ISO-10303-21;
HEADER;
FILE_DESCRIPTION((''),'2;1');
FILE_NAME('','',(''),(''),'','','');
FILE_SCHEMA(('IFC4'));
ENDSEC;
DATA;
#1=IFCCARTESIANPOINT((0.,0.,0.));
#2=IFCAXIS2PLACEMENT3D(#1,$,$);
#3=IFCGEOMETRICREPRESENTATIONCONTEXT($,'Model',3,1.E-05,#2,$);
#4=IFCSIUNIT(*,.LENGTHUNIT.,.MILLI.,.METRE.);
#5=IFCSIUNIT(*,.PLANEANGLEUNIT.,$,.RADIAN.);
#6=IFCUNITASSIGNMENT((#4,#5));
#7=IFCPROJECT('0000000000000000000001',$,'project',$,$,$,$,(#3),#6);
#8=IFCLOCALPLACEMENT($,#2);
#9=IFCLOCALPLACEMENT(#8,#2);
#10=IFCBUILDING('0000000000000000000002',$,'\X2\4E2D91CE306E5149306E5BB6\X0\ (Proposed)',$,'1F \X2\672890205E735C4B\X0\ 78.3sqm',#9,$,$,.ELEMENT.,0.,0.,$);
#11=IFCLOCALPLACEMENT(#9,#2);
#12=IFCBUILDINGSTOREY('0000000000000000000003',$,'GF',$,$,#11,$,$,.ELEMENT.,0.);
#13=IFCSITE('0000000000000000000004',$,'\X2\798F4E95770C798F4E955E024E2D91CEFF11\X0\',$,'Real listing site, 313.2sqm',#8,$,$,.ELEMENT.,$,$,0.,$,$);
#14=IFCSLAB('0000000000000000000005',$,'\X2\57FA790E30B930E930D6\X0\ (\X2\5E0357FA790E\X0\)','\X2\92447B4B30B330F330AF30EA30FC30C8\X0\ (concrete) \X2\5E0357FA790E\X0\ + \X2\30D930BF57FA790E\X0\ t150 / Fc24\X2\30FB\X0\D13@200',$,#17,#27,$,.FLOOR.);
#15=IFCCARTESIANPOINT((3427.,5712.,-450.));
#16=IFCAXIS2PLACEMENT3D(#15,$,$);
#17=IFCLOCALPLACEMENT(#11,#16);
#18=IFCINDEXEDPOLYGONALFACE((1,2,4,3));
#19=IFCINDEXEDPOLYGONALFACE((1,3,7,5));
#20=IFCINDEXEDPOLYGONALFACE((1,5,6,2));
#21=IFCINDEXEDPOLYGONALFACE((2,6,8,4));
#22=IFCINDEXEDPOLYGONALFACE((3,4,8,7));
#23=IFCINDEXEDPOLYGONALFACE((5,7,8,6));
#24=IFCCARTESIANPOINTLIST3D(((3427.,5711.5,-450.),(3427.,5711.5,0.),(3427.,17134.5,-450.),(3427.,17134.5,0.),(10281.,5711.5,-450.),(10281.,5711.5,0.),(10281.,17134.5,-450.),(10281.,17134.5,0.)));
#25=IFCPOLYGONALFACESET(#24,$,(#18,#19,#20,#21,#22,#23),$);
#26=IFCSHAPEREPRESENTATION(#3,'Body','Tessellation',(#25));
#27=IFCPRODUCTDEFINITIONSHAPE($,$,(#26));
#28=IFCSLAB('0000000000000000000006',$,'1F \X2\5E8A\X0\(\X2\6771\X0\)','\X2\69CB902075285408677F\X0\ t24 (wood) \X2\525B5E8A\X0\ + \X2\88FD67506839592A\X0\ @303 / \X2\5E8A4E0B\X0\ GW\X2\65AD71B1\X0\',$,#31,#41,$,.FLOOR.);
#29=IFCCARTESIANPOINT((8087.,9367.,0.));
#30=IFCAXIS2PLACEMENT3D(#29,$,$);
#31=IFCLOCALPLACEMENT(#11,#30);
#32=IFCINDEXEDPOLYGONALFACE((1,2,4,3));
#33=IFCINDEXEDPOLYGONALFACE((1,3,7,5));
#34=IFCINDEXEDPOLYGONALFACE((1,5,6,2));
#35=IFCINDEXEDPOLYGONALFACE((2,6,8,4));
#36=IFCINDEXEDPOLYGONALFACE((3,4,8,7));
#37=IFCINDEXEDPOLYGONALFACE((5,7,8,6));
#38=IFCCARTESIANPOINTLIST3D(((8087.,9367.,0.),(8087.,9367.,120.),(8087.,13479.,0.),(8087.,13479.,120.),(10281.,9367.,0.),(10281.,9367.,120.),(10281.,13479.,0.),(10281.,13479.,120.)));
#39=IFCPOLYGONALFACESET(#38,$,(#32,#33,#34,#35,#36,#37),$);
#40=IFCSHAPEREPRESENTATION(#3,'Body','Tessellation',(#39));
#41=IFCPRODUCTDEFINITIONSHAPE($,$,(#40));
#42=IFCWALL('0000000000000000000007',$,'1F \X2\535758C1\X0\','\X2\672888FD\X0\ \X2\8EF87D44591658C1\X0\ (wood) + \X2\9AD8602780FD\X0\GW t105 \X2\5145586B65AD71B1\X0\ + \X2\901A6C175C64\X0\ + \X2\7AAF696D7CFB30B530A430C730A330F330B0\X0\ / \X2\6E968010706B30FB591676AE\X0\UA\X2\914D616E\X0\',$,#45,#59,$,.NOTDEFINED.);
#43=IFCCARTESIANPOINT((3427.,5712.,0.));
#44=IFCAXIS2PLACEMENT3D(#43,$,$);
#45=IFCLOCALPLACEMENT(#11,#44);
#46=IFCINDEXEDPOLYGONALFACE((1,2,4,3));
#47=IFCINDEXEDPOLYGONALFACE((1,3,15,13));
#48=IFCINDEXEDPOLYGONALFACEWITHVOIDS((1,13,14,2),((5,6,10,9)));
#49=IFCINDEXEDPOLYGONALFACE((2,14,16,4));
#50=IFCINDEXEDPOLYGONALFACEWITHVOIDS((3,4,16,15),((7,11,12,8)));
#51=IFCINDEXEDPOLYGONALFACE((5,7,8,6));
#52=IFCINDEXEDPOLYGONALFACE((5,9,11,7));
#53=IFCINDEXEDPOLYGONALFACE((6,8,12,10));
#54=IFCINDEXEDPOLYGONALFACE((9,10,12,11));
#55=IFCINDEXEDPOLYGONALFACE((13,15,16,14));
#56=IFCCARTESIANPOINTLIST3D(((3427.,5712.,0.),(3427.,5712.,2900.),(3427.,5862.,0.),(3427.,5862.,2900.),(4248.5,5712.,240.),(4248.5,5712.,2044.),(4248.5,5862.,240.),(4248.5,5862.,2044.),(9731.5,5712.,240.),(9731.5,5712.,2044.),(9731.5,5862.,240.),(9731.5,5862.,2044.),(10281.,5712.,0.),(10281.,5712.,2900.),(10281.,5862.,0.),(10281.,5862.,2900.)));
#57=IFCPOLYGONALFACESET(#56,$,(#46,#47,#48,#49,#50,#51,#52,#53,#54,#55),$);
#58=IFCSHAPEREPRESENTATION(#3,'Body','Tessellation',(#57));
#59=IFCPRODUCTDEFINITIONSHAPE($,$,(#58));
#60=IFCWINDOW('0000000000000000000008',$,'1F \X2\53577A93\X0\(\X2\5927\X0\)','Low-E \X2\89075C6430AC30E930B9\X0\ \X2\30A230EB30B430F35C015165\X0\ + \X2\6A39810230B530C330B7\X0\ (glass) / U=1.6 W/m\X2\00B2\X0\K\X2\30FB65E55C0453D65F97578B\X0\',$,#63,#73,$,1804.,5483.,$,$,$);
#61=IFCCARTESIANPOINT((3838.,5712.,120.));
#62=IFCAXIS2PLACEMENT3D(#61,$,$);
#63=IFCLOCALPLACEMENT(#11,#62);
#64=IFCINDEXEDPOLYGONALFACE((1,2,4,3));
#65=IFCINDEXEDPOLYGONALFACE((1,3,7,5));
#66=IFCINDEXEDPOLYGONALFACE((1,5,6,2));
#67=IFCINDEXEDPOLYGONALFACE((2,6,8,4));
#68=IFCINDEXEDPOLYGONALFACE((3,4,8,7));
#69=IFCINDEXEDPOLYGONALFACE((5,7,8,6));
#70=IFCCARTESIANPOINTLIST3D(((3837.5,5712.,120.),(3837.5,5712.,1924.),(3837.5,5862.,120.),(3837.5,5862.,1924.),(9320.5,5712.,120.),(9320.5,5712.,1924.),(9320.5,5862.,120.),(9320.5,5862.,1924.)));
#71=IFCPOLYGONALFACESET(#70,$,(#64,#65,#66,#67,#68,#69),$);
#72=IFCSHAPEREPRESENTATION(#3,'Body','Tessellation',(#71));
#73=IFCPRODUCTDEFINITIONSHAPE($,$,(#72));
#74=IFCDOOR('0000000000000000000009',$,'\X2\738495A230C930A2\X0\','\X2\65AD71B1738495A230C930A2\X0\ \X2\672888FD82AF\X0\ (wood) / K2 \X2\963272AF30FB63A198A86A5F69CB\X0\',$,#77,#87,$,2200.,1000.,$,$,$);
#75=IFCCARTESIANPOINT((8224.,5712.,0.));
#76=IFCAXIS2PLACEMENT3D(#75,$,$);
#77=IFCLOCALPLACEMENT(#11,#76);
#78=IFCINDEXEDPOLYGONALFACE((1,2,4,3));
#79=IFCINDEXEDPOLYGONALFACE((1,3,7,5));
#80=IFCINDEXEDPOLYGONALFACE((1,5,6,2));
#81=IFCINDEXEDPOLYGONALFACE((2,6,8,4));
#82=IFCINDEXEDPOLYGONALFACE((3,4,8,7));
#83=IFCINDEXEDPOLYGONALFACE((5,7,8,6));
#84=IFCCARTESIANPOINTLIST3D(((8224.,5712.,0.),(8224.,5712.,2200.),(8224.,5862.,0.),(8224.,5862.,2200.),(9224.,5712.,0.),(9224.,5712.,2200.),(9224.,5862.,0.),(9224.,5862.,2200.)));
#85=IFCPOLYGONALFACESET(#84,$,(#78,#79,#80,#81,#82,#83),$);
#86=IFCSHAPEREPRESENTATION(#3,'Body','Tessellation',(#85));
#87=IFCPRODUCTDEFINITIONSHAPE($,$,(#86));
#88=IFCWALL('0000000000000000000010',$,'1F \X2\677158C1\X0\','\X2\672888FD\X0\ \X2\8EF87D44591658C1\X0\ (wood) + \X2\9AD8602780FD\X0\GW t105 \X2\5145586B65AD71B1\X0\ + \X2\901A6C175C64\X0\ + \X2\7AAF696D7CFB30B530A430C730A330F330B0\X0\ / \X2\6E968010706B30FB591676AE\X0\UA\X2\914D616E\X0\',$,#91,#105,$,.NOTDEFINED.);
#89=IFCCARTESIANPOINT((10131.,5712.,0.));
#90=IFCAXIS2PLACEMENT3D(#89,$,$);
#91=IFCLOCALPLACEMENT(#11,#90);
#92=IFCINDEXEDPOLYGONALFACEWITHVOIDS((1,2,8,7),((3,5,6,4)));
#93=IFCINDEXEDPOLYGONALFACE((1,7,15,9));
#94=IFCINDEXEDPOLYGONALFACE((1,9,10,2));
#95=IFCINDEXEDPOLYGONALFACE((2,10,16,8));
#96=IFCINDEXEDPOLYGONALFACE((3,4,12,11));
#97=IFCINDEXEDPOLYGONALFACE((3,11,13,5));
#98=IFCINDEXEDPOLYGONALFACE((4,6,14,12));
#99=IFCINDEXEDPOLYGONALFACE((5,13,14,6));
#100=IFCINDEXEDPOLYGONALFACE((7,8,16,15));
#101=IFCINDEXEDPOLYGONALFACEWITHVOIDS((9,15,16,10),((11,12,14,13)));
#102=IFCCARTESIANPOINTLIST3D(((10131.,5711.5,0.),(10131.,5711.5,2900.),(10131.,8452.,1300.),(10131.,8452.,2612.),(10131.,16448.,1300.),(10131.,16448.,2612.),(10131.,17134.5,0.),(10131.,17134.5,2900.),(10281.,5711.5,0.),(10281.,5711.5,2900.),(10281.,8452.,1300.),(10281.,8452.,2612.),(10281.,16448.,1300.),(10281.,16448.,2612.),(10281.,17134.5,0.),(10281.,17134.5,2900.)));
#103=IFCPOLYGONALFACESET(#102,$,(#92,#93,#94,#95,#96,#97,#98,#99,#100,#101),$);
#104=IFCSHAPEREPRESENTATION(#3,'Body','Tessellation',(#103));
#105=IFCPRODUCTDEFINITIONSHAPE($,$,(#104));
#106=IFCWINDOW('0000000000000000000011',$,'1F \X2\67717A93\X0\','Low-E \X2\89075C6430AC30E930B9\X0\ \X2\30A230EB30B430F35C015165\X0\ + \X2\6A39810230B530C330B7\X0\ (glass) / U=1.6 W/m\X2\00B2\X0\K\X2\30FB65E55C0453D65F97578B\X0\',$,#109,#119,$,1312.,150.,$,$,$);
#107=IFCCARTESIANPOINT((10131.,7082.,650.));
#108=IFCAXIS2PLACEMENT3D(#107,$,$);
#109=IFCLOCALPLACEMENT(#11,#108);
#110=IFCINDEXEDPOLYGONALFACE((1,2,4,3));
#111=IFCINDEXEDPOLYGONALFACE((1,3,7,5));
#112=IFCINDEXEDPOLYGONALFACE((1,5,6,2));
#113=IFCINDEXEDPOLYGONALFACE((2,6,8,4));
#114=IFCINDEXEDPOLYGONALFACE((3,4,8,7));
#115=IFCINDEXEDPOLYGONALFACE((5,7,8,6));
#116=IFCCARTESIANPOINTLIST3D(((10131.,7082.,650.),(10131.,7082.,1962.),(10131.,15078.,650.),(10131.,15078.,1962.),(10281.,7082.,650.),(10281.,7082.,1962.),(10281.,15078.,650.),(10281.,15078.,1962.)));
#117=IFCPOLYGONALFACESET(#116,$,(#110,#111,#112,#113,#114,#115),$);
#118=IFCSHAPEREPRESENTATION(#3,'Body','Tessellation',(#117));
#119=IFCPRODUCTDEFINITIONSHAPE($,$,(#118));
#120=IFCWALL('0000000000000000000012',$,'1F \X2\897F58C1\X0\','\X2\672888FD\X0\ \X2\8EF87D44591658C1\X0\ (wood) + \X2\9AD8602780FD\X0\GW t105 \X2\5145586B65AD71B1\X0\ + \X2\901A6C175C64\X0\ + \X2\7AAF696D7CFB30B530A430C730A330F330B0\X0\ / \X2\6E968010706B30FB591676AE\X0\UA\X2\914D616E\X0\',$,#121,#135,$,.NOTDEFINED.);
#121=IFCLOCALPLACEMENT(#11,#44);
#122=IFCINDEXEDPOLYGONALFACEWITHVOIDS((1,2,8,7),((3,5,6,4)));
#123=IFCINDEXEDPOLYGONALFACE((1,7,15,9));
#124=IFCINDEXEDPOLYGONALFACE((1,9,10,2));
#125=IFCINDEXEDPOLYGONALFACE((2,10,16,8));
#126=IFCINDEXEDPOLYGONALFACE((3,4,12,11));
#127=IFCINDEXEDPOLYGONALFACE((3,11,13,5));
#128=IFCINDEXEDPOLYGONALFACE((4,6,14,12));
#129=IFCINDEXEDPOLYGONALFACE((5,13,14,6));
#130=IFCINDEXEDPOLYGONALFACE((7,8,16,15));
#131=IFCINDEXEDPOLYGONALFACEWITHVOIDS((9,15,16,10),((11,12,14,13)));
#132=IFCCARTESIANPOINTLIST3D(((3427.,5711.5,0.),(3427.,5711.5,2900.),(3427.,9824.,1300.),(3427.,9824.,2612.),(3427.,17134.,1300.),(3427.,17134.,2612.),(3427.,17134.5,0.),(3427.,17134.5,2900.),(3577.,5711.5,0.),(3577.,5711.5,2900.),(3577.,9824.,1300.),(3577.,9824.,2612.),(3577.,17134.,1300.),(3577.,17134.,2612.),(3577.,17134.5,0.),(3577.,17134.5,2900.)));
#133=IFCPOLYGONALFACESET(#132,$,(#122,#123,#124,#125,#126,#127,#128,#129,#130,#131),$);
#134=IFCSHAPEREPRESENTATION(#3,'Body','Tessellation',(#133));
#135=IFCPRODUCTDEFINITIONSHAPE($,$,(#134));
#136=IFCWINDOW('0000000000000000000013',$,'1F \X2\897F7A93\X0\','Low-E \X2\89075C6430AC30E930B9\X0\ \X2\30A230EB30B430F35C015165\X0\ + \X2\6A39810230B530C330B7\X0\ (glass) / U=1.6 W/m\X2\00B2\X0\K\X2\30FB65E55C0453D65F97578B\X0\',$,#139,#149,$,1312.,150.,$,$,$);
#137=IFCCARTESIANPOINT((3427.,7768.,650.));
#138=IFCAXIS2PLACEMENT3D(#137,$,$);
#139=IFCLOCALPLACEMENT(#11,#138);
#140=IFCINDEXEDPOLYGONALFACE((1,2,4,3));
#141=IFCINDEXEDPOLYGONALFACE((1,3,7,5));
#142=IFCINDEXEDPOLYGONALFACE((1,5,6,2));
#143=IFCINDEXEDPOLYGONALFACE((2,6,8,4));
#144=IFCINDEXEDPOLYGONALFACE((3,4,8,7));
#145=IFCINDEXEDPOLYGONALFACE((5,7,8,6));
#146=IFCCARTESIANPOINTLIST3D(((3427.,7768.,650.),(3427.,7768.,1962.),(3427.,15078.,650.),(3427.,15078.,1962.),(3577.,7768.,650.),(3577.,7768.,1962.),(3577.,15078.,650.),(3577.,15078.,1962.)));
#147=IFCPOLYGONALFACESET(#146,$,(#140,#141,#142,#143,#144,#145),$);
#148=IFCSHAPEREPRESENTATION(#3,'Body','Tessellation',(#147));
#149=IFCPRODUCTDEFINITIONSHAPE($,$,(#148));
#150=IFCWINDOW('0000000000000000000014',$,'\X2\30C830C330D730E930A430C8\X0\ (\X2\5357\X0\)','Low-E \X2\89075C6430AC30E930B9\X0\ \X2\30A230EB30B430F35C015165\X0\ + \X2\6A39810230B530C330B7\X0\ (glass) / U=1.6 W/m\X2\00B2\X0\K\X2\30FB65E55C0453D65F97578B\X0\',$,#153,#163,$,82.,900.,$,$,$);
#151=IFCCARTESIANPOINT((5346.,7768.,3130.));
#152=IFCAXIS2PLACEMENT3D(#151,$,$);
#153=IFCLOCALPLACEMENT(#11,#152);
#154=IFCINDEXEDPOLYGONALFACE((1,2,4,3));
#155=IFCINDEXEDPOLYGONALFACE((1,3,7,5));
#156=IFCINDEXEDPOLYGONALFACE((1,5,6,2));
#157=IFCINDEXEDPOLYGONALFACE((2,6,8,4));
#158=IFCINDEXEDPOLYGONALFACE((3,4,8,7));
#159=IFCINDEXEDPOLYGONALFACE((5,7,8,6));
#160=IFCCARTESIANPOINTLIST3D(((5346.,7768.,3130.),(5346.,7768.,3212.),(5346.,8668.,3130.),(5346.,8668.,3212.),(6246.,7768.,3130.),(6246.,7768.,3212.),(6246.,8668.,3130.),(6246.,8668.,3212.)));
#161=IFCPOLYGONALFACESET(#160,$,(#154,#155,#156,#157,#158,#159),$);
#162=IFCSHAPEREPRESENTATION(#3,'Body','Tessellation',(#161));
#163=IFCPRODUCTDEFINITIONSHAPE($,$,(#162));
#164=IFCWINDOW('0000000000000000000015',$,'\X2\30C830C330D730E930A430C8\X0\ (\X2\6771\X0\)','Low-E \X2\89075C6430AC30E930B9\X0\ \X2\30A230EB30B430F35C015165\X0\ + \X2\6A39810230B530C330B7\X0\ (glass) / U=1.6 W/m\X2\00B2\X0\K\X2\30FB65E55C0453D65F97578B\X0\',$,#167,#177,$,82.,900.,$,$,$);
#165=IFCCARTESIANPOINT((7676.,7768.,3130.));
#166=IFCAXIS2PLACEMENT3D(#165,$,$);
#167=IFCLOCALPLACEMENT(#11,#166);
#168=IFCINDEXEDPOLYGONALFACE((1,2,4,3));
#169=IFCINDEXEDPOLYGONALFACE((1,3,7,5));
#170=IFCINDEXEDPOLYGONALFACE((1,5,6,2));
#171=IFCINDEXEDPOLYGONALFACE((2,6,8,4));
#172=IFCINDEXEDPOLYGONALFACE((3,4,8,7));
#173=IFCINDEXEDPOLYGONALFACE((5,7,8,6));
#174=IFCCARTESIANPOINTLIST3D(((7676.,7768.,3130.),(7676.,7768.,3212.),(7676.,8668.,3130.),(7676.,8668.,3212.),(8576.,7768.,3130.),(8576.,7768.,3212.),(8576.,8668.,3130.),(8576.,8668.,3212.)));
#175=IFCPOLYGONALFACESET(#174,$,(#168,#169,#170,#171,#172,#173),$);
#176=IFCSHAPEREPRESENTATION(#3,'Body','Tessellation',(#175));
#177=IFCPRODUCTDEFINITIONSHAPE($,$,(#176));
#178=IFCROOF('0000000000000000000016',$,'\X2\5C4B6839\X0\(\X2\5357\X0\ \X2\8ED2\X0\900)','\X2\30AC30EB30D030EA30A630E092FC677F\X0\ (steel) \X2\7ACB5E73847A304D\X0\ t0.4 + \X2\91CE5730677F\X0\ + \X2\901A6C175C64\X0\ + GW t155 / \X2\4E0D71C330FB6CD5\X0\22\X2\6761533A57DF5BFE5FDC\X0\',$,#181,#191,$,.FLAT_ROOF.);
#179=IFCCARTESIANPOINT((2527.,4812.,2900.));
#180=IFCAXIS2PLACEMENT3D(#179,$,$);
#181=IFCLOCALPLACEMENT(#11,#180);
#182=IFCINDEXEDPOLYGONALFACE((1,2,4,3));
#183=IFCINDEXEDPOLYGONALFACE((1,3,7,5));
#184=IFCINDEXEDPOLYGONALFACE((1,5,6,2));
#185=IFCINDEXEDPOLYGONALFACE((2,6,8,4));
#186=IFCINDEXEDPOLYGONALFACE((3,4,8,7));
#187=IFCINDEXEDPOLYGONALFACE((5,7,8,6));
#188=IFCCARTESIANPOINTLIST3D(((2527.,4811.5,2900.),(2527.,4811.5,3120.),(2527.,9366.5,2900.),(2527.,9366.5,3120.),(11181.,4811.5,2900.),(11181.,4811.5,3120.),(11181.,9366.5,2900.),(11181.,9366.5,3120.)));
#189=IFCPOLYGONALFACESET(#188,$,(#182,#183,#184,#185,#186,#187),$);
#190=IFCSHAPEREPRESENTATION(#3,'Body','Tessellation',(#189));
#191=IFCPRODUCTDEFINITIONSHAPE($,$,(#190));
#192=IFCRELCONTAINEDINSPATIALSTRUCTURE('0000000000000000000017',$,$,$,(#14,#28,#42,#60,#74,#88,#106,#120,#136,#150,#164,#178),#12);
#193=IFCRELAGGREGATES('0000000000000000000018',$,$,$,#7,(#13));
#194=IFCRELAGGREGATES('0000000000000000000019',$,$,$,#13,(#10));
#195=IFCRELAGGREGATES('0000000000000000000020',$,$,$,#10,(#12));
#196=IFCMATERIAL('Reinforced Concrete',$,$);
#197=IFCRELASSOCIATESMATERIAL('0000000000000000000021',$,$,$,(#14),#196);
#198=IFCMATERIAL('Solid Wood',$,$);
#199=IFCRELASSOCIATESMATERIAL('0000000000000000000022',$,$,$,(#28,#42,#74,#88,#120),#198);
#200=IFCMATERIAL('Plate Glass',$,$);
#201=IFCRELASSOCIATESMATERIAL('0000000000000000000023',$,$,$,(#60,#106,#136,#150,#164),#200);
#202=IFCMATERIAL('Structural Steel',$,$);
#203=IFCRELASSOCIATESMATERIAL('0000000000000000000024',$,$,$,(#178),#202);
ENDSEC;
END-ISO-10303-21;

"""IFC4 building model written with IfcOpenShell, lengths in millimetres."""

from ifc_helpers import new_model, si_unit, frame, frame_2d, origin, place, context, project, spatial, rectangle, extrude, material, element, fill, save


model = new_model("IFC4")

# Units and contexts
model_context = context("Model", 3, precision=1e-05, world=origin())
ifc_project = project(units=[si_unit("LENGTHUNIT", "METRE", prefix="MILLI"), si_unit("PLANEANGLEUNIT", "RADIAN")], contexts=[model_context])

# Site, building, storey
site_placement = place(None, origin())
site = spatial("IfcSite", under=ifc_project, at=site_placement, Name="福井県福井市中野１", ObjectType="Real listing site, 313.2sqm", CompositionType="ELEMENT", RefElevation=0.0)
building_placement = place(site_placement, origin())
building = spatial("IfcBuilding", under=site, at=building_placement, Name="中野の光の家 (Proposed)", ObjectType="1F 木造平屋 78.3sqm", CompositionType="ELEMENT", ElevationOfRefHeight=0.0, ElevationOfTerrain=0.0)
storey_placement = place(building_placement, origin())
storey = spatial("IfcBuildingStorey", under=building, at=storey_placement, Name="GF", CompositionType="ELEMENT", Elevation=0.0)

# Slabs
ifc_material_1 = material(Name="Reinforced Concrete")
slab_1_placement = place(storey_placement, frame((3427.0, 5712.0, -450.0)))
element("IfcSlab", 1, at=slab_1_placement, inside=storey, material=ifc_material_1, Name="基礎スラブ (布基礎)", Description="鉄筋コンクリート (concrete) 布基礎 + ベタ基礎 t150 / Fc24・D13@200", PredefinedType="FLOOR", context=model_context, shape_type="SweptSolid", body=[
    extrude(rectangle(XDim=6854.0, YDim=11423.0, at=frame_2d((3427.0, 5711.0))), frame((3427.0, 5712.0, -450.0)), (0.0, 0.0, 1.0), 450.0),
])
ifc_material_2 = material(Name="Solid Wood")
slab_2_placement = place(storey_placement, frame((8087.0, 9367.0, 0.0)))
element("IfcSlab", 2, at=slab_2_placement, inside=storey, material=ifc_material_2, Name="1F 床(東)", Description="構造用合板 t24 (wood) 剛床 + 製材根太 @303 / 床下 GW断熱", PredefinedType="FLOOR", context=model_context, shape_type="SweptSolid", body=[
    extrude(rectangle(XDim=2194.0, YDim=4112.0, at=frame_2d((1097.0, 2056.0))), frame((8087.0, 9367.0, 0.0)), (0.0, 0.0, 1.0), 120.0),
])

# Wall, openings, window, door
wall_1_placement = place(storey_placement, frame((3427.0, 5712.0, 0.0)))
wall_1 = element("IfcWall", 3, at=wall_1_placement, inside=storey, material=ifc_material_2, Name="1F 南壁", Description="木製 軸組外壁 (wood) + 高性能GW t105 充填断熱 + 通気層 + 窯業系サイディング / 準耐火・外皮UA配慮", PredefinedType="NOTDEFINED", context=model_context, shape_type="SweptSolid", body=[
    extrude(rectangle(XDim=6854.0, YDim=150.0, at=frame_2d((3427.0, 75.0))), frame((3427.0, 5712.0, 0.0)), (0.0, 0.0, 1.0), 2900.0),
])
opening_1_placement = place(storey_placement, frame((3838.0, 5712.0, 120.0)))
opening_1 = element("IfcOpeningElement", 4, at=opening_1_placement, cuts=wall_1, PredefinedType="NOTDEFINED", context=model_context, shape_type="SweptSolid", body=[
    extrude(rectangle(XDim=5483.0, YDim=150.0, at=frame_2d((2741.0, 75.0))), frame((3838.0, 5712.0, 120.0)), (0.0, 0.0, 1.0), 1804.0),
])
opening_2_placement = place(storey_placement, frame((8224.0, 5712.0, 0.0)))
opening_2 = element("IfcOpeningElement", 5, at=opening_2_placement, cuts=wall_1, PredefinedType="NOTDEFINED", context=model_context, shape_type="SweptSolid", body=[
    extrude(rectangle(XDim=1000.0, YDim=150.0, at=frame_2d((500.0, 75.0))), frame((8224.0, 5712.0, 0.0)), (0.0, 0.0, 1.0), 2200.0),
])
ifc_material_3 = material(Name="Plate Glass")
window_1_placement = place(storey_placement, frame((3838.0, 5712.0, 120.0)))
window_1 = element("IfcWindow", 6, at=window_1_placement, inside=storey, material=ifc_material_3, Name="1F 南窓(大)", Description="Low-E 複層ガラス アルゴン封入 + 樹脂サッシ (glass) / U=1.6 W/m²K・日射取得型", OverallHeight=1804.0, OverallWidth=5483.0, context=model_context, shape_type="SweptSolid", body=[
    extrude(rectangle(XDim=5483.0, YDim=150.0, at=frame_2d((2741.0, 75.0))), frame((3838.0, 5712.0, 120.0)), (0.0, 0.0, 1.0), 1804.0),
])
fill(opening_1, window_1)
door_placement = place(storey_placement, frame((8224.0, 5712.0, 0.0)))
door = element("IfcDoor", 7, at=door_placement, inside=storey, material=ifc_material_2, Name="玄関ドア", Description="断熱玄関ドア 木製芯 (wood) / K2 防犯・採風機構", OverallHeight=2200.0, OverallWidth=1000.0, context=model_context, shape_type="SweptSolid", body=[
    extrude(rectangle(XDim=1000.0, YDim=150.0, at=frame_2d((500.0, 75.0))), frame((8224.0, 5712.0, 0.0)), (0.0, 0.0, 1.0), 2200.0),
])
fill(opening_2, door)

# Walls, openings, windows
wall_2_placement = place(storey_placement, frame((10131.0, 5712.0, 0.0)))
wall_2 = element("IfcWall", 8, at=wall_2_placement, inside=storey, material=ifc_material_2, Name="1F 東壁", Description="木製 軸組外壁 (wood) + 高性能GW t105 充填断熱 + 通気層 + 窯業系サイディング / 準耐火・外皮UA配慮", PredefinedType="NOTDEFINED", context=model_context, shape_type="SweptSolid", body=[
    extrude(rectangle(XDim=150.0, YDim=11423.0, at=frame_2d((75.0, 5711.0))), frame((10131.0, 5712.0, 0.0)), (0.0, 0.0, 1.0), 2900.0),
])
opening_3_placement = place(storey_placement, frame((10131.0, 7082.0, 650.0)))
opening_3 = element("IfcOpeningElement", 9, at=opening_3_placement, cuts=wall_2, PredefinedType="NOTDEFINED", context=model_context, shape_type="SweptSolid", body=[
    extrude(rectangle(XDim=150.0, YDim=7996.0, at=frame_2d((75.0, 3998.0))), frame((10131.0, 7082.0, 650.0)), (0.0, 0.0, 1.0), 1312.0),
])
window_2_placement = place(storey_placement, frame((10131.0, 7082.0, 650.0)))
window_2 = element("IfcWindow", 10, at=window_2_placement, inside=storey, material=ifc_material_3, Name="1F 東窓", Description="Low-E 複層ガラス アルゴン封入 + 樹脂サッシ (glass) / U=1.6 W/m²K・日射取得型", OverallHeight=1312.0, OverallWidth=150.0, context=model_context, shape_type="SweptSolid", body=[
    extrude(rectangle(XDim=150.0, YDim=7996.0, at=frame_2d((75.0, 3998.0))), frame((10131.0, 7082.0, 650.0)), (0.0, 0.0, 1.0), 1312.0),
])
fill(opening_3, window_2)
wall_3_placement = place(storey_placement, frame((3427.0, 5712.0, 0.0)))
wall_3 = element("IfcWall", 11, at=wall_3_placement, inside=storey, material=ifc_material_2, Name="1F 西壁", Description="木製 軸組外壁 (wood) + 高性能GW t105 充填断熱 + 通気層 + 窯業系サイディング / 準耐火・外皮UA配慮", PredefinedType="NOTDEFINED", context=model_context, shape_type="SweptSolid", body=[
    extrude(rectangle(XDim=150.0, YDim=11423.0, at=frame_2d((75.0, 5711.0))), frame((3427.0, 5712.0, 0.0)), (0.0, 0.0, 1.0), 2900.0),
])
opening_4_placement = place(storey_placement, frame((3427.0, 7768.0, 650.0)))
opening_4 = element("IfcOpeningElement", 12, at=opening_4_placement, cuts=wall_3, PredefinedType="NOTDEFINED", context=model_context, shape_type="SweptSolid", body=[
    extrude(rectangle(XDim=150.0, YDim=7310.0, at=frame_2d((75.0, 3655.0))), frame((3427.0, 7768.0, 650.0)), (0.0, 0.0, 1.0), 1312.0),
])
window_3_placement = place(storey_placement, frame((3427.0, 7768.0, 650.0)))
window_3 = element("IfcWindow", 13, at=window_3_placement, inside=storey, material=ifc_material_3, Name="1F 西窓", Description="Low-E 複層ガラス アルゴン封入 + 樹脂サッシ (glass) / U=1.6 W/m²K・日射取得型", OverallHeight=1312.0, OverallWidth=150.0, context=model_context, shape_type="SweptSolid", body=[
    extrude(rectangle(XDim=150.0, YDim=7310.0, at=frame_2d((75.0, 3655.0))), frame((3427.0, 7768.0, 650.0)), (0.0, 0.0, 1.0), 1312.0),
])
fill(opening_4, window_3)

# Windows
window_4_placement = place(storey_placement, frame((5346.0, 7768.0, 3130.0)))
element("IfcWindow", 14, at=window_4_placement, inside=storey, material=ifc_material_3, Name="トップライト (南)", Description="Low-E 複層ガラス アルゴン封入 + 樹脂サッシ (glass) / U=1.6 W/m²K・日射取得型", OverallHeight=82.0, OverallWidth=900.0, context=model_context, shape_type="SweptSolid", body=[
    extrude(rectangle(XDim=900.0, YDim=900.0, at=frame_2d((450.0, 450.0))), frame((5346.0, 7768.0, 3130.0)), (0.0, 0.0, 1.0), 82.0),
])
window_5_placement = place(storey_placement, frame((7676.0, 7768.0, 3130.0)))
element("IfcWindow", 15, at=window_5_placement, inside=storey, material=ifc_material_3, Name="トップライト (東)", Description="Low-E 複層ガラス アルゴン封入 + 樹脂サッシ (glass) / U=1.6 W/m²K・日射取得型", OverallHeight=82.0, OverallWidth=900.0, context=model_context, shape_type="SweptSolid", body=[
    extrude(rectangle(XDim=900.0, YDim=900.0, at=frame_2d((450.0, 450.0))), frame((7676.0, 7768.0, 3130.0)), (0.0, 0.0, 1.0), 82.0),
])

# Roof
ifc_material_4 = material(Name="Structural Steel")
roof_placement = place(storey_placement, frame((2527.0, 4812.0, 2900.0)))
element("IfcRoof", 16, at=roof_placement, inside=storey, material=ifc_material_4, Name="屋根(南 軒900)", Description="ガルバリウム鋼板 (steel) 立平葺き t0.4 + 野地板 + 通気層 + GW t155 / 不燃・法22条区域対応", PredefinedType="FLAT_ROOF", context=model_context, shape_type="SweptSolid", body=[
    extrude(rectangle(XDim=8654.0, YDim=4555.0, at=frame_2d((4327.0, 2277.0))), frame((2527.0, 4812.0, 2900.0)), (0.0, 0.0, 1.0), 220.0),
])

save(model, "model.ifc")
